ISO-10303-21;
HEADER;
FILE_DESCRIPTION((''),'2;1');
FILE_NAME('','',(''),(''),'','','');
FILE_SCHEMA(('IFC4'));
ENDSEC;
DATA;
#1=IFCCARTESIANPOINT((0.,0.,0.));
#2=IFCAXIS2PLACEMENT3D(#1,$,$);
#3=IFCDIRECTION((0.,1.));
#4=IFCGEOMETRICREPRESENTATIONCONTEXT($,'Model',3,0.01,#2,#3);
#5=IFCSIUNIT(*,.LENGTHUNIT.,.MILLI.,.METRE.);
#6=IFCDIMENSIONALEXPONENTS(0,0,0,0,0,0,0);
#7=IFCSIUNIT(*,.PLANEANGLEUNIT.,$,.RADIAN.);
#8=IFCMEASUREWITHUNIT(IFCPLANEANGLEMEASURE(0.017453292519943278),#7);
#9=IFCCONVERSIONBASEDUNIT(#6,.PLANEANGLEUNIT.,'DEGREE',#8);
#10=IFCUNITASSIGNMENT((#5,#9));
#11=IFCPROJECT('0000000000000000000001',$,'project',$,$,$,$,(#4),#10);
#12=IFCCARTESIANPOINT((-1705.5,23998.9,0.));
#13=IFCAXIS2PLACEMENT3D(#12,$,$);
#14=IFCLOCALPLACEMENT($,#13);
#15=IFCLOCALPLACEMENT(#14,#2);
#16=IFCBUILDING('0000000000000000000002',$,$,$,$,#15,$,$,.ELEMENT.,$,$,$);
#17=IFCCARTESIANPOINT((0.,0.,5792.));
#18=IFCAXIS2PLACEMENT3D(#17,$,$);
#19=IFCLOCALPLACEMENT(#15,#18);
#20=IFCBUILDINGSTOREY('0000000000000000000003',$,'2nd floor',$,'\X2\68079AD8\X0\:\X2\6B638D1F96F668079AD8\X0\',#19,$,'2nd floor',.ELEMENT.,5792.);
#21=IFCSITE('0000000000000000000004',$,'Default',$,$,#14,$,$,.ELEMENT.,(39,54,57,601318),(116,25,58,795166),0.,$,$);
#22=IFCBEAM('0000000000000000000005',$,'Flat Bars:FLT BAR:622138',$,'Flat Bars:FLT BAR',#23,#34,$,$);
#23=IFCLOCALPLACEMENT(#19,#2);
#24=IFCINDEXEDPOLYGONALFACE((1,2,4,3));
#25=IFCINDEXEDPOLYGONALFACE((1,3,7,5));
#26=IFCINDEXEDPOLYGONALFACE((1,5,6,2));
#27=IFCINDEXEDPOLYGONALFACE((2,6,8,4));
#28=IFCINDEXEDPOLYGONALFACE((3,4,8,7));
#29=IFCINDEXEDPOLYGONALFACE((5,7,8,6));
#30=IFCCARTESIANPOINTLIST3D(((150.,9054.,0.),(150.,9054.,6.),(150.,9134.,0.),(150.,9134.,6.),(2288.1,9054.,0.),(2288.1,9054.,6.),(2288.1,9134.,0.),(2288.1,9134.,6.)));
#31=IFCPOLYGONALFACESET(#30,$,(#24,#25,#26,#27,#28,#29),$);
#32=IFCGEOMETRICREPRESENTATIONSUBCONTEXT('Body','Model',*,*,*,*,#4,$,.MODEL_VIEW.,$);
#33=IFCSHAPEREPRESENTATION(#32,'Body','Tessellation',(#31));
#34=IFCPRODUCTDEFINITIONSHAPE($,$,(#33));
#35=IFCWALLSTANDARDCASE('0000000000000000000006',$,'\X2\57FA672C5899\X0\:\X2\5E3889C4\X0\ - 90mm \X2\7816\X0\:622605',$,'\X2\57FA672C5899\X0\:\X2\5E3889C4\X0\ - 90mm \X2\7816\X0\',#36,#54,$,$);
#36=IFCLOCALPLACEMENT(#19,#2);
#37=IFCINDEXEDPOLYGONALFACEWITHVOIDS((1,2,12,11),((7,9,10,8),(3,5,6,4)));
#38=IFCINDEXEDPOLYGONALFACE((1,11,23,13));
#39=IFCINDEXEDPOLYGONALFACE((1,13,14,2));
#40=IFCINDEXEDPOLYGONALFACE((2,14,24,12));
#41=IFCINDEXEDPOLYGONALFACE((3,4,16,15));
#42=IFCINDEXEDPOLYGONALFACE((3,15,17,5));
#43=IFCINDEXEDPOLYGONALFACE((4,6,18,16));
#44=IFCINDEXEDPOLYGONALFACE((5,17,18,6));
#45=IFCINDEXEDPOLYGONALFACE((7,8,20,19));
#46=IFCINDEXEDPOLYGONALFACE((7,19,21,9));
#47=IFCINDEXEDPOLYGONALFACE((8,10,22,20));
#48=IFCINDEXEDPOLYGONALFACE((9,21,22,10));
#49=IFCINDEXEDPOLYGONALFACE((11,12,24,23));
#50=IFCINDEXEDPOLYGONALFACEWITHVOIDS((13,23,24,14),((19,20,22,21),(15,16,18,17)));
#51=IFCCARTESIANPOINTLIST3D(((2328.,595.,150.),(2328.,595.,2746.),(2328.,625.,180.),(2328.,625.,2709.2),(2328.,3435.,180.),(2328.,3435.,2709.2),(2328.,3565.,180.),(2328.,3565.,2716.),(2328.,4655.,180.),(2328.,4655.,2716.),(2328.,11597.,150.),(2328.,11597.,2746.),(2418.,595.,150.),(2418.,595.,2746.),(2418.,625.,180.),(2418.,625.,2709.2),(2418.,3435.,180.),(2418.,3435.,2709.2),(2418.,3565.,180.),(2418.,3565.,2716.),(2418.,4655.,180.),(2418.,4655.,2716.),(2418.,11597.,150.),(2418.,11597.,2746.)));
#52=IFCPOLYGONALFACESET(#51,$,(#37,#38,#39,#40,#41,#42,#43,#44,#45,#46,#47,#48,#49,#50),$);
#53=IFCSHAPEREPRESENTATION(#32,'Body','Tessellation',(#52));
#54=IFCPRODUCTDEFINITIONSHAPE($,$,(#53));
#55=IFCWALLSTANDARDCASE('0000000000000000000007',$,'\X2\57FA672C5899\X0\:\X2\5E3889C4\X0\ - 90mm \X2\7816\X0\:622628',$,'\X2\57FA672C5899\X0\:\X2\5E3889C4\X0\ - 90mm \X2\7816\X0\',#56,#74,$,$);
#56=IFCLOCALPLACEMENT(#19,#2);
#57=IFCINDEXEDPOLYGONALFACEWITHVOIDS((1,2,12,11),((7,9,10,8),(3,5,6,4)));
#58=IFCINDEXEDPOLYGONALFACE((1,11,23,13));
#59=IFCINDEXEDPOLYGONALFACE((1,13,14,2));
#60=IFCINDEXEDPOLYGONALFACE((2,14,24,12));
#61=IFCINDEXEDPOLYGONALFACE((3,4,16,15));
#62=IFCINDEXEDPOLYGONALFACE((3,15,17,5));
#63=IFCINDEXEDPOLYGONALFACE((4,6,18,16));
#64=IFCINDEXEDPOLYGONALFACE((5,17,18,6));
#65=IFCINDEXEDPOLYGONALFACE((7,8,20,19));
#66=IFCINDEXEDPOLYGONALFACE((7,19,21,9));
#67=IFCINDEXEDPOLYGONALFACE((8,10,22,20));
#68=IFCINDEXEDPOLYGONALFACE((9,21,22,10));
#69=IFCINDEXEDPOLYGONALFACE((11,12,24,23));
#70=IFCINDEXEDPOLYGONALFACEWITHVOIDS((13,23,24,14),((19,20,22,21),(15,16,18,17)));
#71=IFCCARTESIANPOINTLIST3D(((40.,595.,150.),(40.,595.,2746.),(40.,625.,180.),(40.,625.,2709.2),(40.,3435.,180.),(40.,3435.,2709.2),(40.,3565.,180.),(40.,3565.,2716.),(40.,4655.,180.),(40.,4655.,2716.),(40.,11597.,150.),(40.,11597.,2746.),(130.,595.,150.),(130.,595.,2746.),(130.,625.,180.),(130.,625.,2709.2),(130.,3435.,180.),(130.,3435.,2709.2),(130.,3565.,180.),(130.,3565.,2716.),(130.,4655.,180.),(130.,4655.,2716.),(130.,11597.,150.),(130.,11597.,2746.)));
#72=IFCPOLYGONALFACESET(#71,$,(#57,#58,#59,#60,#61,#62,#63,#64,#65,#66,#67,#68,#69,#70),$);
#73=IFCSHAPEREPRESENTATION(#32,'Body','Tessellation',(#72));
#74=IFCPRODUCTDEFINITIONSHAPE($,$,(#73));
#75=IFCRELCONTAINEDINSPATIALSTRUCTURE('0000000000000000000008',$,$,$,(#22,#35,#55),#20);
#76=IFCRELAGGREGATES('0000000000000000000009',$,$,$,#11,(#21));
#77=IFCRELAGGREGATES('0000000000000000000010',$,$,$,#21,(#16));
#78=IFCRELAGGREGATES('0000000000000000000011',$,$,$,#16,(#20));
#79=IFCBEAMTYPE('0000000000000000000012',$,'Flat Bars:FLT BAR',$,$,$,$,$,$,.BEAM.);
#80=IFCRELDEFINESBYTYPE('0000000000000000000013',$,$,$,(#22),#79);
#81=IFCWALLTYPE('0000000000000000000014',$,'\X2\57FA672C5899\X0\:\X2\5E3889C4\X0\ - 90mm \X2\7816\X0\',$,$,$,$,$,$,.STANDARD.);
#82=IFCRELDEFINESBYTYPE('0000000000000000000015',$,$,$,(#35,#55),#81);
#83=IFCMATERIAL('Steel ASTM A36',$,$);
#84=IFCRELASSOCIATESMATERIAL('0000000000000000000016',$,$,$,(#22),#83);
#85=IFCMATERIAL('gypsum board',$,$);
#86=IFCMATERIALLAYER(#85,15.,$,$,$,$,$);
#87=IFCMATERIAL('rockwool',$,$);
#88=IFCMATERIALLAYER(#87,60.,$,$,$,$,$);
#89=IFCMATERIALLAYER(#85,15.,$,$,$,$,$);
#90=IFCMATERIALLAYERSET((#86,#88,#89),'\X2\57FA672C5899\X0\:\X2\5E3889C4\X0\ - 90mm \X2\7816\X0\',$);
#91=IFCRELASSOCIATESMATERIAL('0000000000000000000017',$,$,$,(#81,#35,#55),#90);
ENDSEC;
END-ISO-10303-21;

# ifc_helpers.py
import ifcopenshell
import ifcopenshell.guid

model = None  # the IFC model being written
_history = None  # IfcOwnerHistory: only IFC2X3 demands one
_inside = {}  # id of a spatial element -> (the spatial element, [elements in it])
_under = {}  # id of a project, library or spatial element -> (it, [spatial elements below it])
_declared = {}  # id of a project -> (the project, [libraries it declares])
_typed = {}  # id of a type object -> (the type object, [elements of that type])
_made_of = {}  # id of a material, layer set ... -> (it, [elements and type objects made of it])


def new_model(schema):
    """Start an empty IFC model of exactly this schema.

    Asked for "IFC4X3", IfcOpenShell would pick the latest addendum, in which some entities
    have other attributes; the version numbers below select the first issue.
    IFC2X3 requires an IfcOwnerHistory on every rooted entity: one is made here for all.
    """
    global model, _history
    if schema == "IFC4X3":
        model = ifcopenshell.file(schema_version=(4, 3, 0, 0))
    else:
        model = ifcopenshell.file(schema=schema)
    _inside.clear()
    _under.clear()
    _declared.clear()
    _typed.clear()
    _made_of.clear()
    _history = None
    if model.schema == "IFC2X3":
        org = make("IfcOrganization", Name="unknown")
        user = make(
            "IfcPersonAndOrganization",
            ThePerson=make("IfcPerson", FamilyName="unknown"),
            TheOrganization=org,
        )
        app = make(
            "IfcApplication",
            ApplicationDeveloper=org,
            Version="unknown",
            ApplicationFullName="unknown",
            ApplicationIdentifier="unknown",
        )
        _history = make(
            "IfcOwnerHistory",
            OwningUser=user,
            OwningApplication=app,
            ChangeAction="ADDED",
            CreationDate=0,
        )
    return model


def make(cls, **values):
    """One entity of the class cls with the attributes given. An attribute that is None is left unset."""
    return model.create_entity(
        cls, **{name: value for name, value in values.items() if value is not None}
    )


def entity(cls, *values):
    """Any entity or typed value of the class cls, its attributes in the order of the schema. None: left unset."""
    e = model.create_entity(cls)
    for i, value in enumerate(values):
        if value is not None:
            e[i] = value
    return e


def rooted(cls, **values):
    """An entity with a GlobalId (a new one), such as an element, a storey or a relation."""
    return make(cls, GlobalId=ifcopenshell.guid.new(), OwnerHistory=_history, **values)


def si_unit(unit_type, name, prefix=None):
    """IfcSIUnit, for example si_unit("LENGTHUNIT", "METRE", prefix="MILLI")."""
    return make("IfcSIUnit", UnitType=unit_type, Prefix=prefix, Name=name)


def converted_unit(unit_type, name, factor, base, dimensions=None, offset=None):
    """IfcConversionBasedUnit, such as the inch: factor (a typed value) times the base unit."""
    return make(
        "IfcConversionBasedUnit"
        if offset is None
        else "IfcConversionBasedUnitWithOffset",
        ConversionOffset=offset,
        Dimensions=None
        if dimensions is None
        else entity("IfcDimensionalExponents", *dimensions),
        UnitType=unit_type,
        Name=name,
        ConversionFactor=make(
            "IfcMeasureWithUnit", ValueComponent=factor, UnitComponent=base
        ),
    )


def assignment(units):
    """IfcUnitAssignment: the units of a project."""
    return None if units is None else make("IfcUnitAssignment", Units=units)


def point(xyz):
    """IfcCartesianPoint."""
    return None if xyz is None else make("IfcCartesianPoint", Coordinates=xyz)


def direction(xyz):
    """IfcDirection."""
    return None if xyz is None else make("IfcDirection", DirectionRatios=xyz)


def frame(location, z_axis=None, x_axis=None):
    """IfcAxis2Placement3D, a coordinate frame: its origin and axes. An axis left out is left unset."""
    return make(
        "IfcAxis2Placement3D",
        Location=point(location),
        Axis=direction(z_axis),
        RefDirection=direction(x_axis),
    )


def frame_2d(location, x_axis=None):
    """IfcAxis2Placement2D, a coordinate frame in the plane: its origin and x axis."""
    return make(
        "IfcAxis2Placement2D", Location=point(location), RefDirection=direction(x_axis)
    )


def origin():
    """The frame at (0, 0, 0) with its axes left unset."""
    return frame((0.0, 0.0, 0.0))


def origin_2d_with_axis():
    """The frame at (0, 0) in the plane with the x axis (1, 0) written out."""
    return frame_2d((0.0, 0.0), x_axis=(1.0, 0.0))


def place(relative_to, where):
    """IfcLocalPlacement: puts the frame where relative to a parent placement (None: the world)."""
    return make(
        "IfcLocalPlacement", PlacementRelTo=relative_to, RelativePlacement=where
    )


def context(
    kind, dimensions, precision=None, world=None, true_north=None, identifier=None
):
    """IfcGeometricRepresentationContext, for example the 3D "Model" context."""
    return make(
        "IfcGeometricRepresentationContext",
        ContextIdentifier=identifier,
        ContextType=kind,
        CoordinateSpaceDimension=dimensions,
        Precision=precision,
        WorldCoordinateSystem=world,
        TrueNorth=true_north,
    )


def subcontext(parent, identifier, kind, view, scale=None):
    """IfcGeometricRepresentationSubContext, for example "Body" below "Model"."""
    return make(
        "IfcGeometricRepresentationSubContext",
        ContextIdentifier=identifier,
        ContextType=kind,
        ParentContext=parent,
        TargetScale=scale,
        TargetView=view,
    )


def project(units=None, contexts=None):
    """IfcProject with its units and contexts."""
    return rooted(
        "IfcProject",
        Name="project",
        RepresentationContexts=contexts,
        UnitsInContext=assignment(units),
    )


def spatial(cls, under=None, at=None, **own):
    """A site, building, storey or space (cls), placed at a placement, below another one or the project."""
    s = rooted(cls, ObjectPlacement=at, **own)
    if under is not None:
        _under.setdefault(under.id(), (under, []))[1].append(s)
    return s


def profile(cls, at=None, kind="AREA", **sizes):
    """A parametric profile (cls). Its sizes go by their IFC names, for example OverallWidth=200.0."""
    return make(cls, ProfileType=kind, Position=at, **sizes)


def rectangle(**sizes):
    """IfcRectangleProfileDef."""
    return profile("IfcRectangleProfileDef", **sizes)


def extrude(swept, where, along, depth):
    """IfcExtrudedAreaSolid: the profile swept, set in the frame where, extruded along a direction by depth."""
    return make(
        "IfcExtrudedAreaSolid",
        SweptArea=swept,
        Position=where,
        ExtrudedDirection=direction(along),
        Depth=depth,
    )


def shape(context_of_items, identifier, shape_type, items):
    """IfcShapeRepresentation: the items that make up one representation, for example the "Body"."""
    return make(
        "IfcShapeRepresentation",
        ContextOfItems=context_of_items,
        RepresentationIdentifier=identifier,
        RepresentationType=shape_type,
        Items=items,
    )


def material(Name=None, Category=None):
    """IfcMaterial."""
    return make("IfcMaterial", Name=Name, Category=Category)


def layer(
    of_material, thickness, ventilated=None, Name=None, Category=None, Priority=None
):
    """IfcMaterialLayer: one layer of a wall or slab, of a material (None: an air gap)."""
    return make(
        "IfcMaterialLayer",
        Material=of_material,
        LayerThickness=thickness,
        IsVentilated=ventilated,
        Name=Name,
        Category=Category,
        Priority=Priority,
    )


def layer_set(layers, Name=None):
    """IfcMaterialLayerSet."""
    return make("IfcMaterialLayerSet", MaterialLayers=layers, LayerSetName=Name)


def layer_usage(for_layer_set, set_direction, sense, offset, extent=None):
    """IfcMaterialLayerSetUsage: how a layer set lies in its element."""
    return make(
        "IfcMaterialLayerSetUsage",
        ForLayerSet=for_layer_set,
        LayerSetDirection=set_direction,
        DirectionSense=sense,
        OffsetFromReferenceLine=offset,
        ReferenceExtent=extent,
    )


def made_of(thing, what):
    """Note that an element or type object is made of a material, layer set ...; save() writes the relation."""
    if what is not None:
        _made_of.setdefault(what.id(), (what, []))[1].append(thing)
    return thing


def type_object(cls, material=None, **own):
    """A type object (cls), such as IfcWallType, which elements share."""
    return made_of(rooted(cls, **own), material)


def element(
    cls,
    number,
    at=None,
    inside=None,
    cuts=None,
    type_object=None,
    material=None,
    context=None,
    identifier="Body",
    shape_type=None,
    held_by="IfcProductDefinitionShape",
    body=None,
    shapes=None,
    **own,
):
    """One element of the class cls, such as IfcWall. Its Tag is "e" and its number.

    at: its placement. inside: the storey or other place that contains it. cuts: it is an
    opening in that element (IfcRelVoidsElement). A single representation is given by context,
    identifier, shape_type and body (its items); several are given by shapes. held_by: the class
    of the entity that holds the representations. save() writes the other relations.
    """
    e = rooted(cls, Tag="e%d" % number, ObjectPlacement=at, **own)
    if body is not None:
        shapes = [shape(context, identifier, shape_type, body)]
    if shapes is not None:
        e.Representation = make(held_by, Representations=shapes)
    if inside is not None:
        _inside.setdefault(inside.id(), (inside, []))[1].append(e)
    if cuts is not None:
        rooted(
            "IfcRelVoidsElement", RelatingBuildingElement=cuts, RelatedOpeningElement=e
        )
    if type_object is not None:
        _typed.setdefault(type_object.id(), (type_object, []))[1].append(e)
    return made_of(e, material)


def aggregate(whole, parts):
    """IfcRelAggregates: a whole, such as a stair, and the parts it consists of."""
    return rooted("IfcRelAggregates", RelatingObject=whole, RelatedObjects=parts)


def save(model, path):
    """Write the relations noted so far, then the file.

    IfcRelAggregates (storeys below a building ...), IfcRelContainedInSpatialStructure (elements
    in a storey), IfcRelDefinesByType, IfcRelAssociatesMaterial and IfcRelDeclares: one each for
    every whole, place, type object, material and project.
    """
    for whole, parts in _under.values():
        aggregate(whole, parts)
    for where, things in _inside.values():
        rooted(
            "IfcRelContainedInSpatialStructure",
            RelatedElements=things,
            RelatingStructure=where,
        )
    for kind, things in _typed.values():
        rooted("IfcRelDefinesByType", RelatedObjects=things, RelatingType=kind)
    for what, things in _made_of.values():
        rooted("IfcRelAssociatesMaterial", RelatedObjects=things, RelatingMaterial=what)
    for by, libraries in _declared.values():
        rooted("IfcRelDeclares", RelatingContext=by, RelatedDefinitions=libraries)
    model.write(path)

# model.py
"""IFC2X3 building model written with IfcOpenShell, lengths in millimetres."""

from ifc_helpers import new_model, entity, si_unit, converted_unit, direction, frame, frame_2d, origin, origin_2d_with_axis, place, context, subcontext, project, spatial, rectangle, extrude, material, layer, layer_set, layer_usage, type_object, element, save


model = new_model("IFC2X3")

# Units and contexts
model_context = context("Model", 3, precision=0.01, world=origin(), true_north=direction((0.0, 1.0)))
body_context = subcontext(model_context, "Body", "Model", "MODEL_VIEW")
ifc_project = project(units=[si_unit("LENGTHUNIT", "METRE", prefix="MILLI"), converted_unit("PLANEANGLEUNIT", "DEGREE", entity("IfcPlaneAngleMeasure", 0.017453292519943278), si_unit("PLANEANGLEUNIT", "RADIAN"), dimensions=[0, 0, 0, 0, 0, 0, 0])], contexts=[model_context])

# Site, building, storey
site_placement = place(None, frame((-1705.5, 23998.9, 0.0)))
site = spatial("IfcSite", under=ifc_project, at=site_placement, Name="Default", CompositionType="ELEMENT", RefLatitude=(39, 54, 57, 601318), RefLongitude=(116, 25, 58, 795166), RefElevation=0.0)
building_placement = place(site_placement, origin())
building = spatial("IfcBuilding", under=site, at=building_placement, CompositionType="ELEMENT")
storey_placement = place(building_placement, frame((0.0, 0.0, 5792.0)))
storey = spatial("IfcBuildingStorey", under=building, at=storey_placement, Name="2nd floor", ObjectType="标高:正负零标高", LongName="2nd floor", CompositionType="ELEMENT", Elevation=5792.0)

# Beam
ifc_material_1 = material(Name="Steel ASTM A36")
beam_type_1 = type_object("IfcBeamType", Name="Flat Bars:FLT BAR", PredefinedType="BEAM")
beam_1_placement = place(storey_placement, frame((150.0, 9094.0, 6.0)))
element("IfcBeam", 1, at=beam_1_placement, inside=storey, type_object=beam_type_1, material=ifc_material_1, Name="Flat Bars:FLT BAR:622138", ObjectType="Flat Bars:FLT BAR", context=body_context, shape_type="SweptSolid", body=[
    extrude(rectangle(XDim=6.0, YDim=80.0, at=origin_2d_with_axis()), frame((0.0, 0.0, -3.0), z_axis=(1.0, 0.0, 0.0), x_axis=(0.0, 0.0, -1.0)), (0.0, 0.0, 1.0), 2138.1),
])

# Shared definitions
ifc_material_2 = material(Name="gypsum board")
ifc_layer_1 = layer(ifc_material_2, 15.0)
ifc_material_3 = material(Name="rockwool")
ifc_layer_2 = layer(ifc_material_3, 60.0)
ifc_layer_3 = layer(ifc_material_2, 15.0)
ifc_layer_set = layer_set([ifc_layer_1, ifc_layer_2, ifc_layer_3], Name="基本墙:常规 - 90mm 砖")
wall_type = type_object("IfcWallType", Name="基本墙:常规 - 90mm 砖", PredefinedType="STANDARD", material=ifc_layer_set)

# Walls, openings
ifc_layer_usage_1 = layer_usage(ifc_layer_set, "AXIS2", "NEGATIVE", 45.0)
wall_1_placement = place(storey_placement, frame((2373.0, 11597.0, 150.0), z_axis=(0.0, 0.0, 1.0), x_axis=(0.0, -1.0, 0.0)))
wall_1 = element("IfcWallStandardCase", 2, at=wall_1_placement, inside=storey, type_object=wall_type, material=ifc_layer_usage_1, Name="基本墙:常规 - 90mm 砖:622605", ObjectType="基本墙:常规 - 90mm 砖", context=body_context, shape_type="SweptSolid", body=[
    extrude(rectangle(XDim=11002.0, YDim=90.0, at=frame_2d((5501.0, 0.0), x_axis=(-1.0, 0.0))), origin(), (0.0, 0.0, 1.0), 2596.0),
])
opening_1_placement = place(wall_1_placement, origin())
element("IfcOpeningElement", 3, at=opening_1_placement, cuts=wall_1, ObjectType="Opening", context=body_context, shape_type="SweptSolid", body=[
    extrude(rectangle(XDim=2536.0, YDim=1090.0, at=frame_2d((0.0, 0.0), x_axis=(0.0, 1.0))), frame((7487.0, 45.0, 1298.0), z_axis=(0.0, -1.0, 0.0), x_axis=(-1.0, 0.0, 0.0)), (0.0, 0.0, 1.0), 90.0),
])
opening_2_placement = place(wall_1_placement, origin())
element("IfcOpeningElement", 4, at=opening_2_placement, cuts=wall_1, ObjectType="Opening", context=body_context, shape_type="SweptSolid", body=[
    extrude(rectangle(XDim=2529.2, YDim=2810.0, at=frame_2d((0.0, 0.0), x_axis=(0.0, 1.0))), frame((9567.0, 45.0, 1294.6), z_axis=(0.0, -1.0, 0.0), x_axis=(-1.0, 0.0, 0.0)), (0.0, 0.0, 1.0), 90.0),
])
ifc_layer_usage_2 = layer_usage(ifc_layer_set, "AXIS2", "NEGATIVE", 45.0)
wall_2_placement = place(storey_placement, frame((85.0, 11597.0, 150.0), z_axis=(0.0, 0.0, 1.0), x_axis=(0.0, -1.0, 0.0)))
wall_2 = element("IfcWallStandardCase", 5, at=wall_2_placement, inside=storey, type_object=wall_type, material=ifc_layer_usage_2, Name="基本墙:常规 - 90mm 砖:622628", ObjectType="基本墙:常规 - 90mm 砖", context=body_context, shape_type="SweptSolid", body=[
    extrude(rectangle(XDim=11002.0, YDim=90.0, at=frame_2d((5501.0, 0.0), x_axis=(-1.0, 0.0))), origin(), (0.0, 0.0, 1.0), 2596.0),
])
opening_3_placement = place(wall_2_placement, origin())
element("IfcOpeningElement", 6, at=opening_3_placement, cuts=wall_2, ObjectType="Opening", context=body_context, shape_type="SweptSolid", body=[
    extrude(rectangle(XDim=2536.0, YDim=1090.0, at=frame_2d((0.0, 0.0), x_axis=(0.0, 1.0))), frame((7487.0, 45.0, 1298.0), z_axis=(0.0, -1.0, 0.0), x_axis=(-1.0, 0.0, 0.0)), (0.0, 0.0, 1.0), 90.0),
])
opening_4_placement = place(wall_2_placement, origin())
element("IfcOpeningElement", 7, at=opening_4_placement, cuts=wall_2, ObjectType="Opening", context=body_context, shape_type="SweptSolid", body=[
    extrude(rectangle(XDim=2529.2, YDim=2810.0, at=frame_2d((0.0, 0.0), x_axis=(0.0, 1.0))), frame((9567.0, 45.0, 1294.6), z_axis=(0.0, -1.0, 0.0), x_axis=(-1.0, 0.0, 0.0)), (0.0, 0.0, 1.0), 90.0),
])

save(model, "model.ifc")
